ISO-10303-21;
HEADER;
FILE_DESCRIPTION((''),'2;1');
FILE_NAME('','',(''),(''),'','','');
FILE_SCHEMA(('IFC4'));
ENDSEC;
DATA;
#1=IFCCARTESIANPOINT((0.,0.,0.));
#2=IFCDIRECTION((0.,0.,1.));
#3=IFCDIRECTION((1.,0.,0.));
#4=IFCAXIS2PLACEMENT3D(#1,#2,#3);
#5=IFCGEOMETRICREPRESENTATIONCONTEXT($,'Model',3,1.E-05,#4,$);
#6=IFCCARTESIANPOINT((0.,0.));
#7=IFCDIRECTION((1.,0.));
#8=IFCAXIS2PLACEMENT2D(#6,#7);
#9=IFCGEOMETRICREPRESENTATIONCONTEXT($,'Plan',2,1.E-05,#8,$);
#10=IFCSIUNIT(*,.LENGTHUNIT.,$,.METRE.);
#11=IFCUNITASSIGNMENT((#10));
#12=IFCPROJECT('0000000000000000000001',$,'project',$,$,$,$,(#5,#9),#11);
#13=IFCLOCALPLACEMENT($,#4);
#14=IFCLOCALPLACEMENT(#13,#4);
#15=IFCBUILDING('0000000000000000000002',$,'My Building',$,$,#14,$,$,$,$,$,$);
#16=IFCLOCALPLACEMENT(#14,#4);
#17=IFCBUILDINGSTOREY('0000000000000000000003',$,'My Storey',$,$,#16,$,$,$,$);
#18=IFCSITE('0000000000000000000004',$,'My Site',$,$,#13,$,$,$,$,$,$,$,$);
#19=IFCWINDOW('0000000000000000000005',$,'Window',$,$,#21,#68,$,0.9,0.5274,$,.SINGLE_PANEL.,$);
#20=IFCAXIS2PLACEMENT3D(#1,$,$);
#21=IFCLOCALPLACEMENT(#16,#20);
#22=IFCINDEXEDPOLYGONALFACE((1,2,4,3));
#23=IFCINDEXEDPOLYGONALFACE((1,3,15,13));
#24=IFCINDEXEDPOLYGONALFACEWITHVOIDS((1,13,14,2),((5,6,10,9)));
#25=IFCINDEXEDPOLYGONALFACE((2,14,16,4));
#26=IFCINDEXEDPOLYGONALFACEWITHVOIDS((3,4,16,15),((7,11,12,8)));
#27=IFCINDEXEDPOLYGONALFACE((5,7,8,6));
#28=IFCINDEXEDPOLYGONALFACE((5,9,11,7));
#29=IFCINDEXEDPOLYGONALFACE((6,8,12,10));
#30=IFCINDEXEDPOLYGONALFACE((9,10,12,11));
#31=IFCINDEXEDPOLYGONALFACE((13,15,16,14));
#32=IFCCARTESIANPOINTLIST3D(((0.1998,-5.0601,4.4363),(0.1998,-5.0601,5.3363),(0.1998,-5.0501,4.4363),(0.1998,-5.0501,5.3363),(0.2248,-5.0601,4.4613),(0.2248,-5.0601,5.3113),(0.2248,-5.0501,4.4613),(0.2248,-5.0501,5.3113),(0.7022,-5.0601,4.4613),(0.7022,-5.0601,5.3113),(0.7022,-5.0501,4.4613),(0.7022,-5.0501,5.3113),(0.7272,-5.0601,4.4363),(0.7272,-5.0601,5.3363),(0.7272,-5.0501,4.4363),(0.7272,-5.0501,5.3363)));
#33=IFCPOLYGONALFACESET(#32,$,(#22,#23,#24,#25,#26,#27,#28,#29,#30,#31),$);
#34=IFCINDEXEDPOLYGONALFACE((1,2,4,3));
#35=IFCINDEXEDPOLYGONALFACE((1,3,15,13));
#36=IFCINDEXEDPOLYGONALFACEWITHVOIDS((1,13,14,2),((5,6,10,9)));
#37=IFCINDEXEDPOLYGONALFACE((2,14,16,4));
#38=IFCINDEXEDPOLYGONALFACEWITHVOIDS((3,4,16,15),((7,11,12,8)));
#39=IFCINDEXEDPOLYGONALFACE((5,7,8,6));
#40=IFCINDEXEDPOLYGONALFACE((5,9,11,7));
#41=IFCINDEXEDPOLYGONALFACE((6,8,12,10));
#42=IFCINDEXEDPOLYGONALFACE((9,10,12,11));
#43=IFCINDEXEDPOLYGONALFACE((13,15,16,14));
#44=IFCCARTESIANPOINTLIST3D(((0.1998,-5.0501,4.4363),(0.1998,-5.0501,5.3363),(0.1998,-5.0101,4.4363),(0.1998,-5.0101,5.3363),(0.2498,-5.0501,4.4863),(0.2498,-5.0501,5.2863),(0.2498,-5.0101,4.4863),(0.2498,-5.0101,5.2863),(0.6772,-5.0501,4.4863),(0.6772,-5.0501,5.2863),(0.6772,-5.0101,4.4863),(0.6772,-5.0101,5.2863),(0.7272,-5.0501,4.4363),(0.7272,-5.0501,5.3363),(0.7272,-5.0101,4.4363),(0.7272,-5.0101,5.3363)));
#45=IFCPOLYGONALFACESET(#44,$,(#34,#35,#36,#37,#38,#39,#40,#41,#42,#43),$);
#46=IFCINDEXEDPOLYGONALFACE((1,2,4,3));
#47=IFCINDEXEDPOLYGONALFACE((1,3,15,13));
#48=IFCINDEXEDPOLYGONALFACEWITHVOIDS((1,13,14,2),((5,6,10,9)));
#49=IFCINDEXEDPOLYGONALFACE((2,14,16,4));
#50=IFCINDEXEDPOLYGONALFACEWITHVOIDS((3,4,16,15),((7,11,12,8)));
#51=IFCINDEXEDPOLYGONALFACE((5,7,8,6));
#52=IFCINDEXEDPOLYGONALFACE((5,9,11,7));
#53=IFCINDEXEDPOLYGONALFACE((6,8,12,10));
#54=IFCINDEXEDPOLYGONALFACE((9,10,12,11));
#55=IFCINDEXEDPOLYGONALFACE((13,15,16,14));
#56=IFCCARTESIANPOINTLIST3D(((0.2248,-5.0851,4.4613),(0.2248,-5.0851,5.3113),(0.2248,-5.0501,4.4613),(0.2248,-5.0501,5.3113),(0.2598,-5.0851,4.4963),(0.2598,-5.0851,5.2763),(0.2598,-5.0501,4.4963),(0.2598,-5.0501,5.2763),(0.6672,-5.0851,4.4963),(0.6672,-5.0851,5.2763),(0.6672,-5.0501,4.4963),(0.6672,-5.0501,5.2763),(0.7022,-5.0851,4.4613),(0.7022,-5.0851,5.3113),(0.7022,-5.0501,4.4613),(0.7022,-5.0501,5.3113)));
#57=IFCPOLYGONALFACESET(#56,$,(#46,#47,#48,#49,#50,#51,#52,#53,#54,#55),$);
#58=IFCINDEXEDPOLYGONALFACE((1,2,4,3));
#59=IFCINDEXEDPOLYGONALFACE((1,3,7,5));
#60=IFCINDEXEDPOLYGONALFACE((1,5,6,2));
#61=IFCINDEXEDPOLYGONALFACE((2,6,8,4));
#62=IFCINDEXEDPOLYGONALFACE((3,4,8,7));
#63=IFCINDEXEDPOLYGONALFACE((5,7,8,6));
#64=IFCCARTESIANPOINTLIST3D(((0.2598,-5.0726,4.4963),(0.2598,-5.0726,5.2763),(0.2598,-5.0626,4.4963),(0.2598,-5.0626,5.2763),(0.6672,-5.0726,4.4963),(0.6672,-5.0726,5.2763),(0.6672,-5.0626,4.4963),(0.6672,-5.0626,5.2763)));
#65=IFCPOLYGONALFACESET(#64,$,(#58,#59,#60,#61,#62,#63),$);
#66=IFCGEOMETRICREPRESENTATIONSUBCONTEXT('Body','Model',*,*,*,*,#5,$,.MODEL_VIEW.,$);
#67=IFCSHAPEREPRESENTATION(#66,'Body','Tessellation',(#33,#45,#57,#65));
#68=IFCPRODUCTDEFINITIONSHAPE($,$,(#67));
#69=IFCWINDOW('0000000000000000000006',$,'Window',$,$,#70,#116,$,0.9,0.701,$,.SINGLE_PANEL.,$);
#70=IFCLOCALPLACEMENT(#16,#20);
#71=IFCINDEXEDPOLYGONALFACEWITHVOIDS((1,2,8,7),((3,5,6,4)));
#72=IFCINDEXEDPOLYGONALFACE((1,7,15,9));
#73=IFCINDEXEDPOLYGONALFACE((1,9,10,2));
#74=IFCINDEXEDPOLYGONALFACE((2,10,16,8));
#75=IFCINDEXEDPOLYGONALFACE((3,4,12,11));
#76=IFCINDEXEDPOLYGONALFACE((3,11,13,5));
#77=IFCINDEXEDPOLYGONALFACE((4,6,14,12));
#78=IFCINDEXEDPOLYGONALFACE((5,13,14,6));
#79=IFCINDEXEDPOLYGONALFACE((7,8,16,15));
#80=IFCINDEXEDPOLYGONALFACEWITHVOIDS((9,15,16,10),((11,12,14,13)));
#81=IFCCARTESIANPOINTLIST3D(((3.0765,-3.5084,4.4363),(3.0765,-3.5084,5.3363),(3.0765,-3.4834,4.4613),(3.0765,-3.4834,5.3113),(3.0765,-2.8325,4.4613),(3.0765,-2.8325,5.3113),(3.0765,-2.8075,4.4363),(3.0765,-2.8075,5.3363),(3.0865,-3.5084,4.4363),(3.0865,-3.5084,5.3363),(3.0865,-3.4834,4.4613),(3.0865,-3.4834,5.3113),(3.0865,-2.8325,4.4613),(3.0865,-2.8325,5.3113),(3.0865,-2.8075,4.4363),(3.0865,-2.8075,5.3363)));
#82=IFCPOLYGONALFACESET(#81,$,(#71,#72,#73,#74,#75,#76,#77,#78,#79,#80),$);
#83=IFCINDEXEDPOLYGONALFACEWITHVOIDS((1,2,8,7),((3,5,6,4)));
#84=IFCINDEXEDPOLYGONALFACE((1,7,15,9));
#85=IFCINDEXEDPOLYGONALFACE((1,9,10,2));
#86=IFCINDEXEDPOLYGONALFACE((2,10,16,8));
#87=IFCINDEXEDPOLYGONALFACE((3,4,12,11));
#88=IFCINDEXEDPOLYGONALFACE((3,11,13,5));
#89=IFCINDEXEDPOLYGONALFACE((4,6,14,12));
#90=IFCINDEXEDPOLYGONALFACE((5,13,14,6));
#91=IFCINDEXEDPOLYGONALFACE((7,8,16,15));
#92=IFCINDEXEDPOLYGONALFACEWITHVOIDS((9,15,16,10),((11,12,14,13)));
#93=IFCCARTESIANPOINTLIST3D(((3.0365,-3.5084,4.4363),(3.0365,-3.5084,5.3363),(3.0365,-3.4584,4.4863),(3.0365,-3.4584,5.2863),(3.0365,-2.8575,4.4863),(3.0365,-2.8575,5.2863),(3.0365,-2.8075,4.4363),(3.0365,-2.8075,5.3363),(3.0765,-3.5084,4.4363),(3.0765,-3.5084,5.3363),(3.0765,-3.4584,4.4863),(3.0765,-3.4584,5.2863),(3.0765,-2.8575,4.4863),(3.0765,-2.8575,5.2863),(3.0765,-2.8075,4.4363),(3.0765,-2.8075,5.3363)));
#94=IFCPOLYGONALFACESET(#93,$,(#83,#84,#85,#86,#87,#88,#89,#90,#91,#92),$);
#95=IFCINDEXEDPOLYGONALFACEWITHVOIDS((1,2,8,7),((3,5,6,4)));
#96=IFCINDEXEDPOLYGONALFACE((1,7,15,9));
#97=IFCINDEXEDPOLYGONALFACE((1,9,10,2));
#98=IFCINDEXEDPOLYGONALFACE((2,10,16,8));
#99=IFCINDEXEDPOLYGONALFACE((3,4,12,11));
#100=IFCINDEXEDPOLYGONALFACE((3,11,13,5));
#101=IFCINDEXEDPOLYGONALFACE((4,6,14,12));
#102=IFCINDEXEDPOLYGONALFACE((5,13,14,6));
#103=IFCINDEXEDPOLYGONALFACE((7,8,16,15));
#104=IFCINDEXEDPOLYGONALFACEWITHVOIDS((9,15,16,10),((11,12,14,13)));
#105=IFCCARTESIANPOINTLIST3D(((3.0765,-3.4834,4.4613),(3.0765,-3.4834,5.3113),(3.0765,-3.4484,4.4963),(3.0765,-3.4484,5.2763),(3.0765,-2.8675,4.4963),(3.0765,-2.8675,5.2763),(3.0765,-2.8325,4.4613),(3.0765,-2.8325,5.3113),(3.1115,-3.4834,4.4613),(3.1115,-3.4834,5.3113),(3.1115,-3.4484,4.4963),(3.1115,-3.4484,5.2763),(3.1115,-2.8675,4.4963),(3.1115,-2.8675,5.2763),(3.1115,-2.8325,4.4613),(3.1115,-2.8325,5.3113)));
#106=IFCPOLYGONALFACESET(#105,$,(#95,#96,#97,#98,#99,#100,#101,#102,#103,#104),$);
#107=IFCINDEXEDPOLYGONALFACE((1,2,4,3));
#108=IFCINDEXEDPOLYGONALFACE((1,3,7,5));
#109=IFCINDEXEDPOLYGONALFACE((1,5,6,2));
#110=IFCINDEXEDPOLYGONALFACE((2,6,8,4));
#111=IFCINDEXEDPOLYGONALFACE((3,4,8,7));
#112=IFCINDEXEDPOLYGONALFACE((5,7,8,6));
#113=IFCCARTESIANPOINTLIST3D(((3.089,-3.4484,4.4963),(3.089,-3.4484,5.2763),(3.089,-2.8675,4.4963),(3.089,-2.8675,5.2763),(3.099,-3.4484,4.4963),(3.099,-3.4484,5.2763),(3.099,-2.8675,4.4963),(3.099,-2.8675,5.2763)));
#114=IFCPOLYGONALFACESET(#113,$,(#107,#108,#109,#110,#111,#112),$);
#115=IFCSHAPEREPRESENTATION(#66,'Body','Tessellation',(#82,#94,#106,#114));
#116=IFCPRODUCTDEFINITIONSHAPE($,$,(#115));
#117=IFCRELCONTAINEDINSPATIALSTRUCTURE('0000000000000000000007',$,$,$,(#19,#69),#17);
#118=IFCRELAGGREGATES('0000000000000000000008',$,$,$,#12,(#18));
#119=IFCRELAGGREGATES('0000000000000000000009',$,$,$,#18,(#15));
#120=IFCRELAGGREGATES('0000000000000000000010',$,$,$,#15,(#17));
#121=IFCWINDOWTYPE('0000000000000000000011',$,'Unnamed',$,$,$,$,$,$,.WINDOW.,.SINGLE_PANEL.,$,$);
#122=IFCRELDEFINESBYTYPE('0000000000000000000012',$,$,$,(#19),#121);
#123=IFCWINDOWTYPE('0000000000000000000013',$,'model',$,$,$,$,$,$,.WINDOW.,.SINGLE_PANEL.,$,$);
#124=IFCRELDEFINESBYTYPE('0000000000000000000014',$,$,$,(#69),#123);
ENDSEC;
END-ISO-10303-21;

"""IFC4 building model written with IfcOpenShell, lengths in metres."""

from ifc_helpers import new_model, entity, si_unit, frame, origin_with_axes, origin_2d_with_axis, place, context, subcontext, project, spatial, line, indexed_curve, outline, extrude, shape, source, transform, mapped, type_object, type_shapes, element, save


model = new_model("IFC4")

# Units and contexts
model_context = context("Model", 3, precision=1e-05, world=origin_with_axes())
plan_context = context("Plan", 2, precision=1e-05, world=origin_2d_with_axis())
body_context_1 = subcontext(model_context, "Body", "Model", "MODEL_VIEW")
body_context_2 = subcontext(plan_context, "Body", "Plan", "PLAN_VIEW")
ifc_project = project(units=[si_unit("LENGTHUNIT", "METRE")], contexts=[model_context, plan_context])

# Site, building, storey
site_placement = place(None, origin_with_axes())
site = spatial("IfcSite", under=ifc_project, at=site_placement, Name="My Site")
building_placement = place(site_placement, origin_with_axes())
building = spatial("IfcBuilding", under=site, at=building_placement, Name="My Building")
storey_placement = place(building_placement, origin_with_axes())
storey = spatial("IfcBuildingStorey", under=building, at=storey_placement, Name="My Storey")

# Shared definitions
window_type_1 = type_object("IfcWindowType", Name="Unnamed", PartitioningType="SINGLE_PANEL", PredefinedType="WINDOW")
shared_shape_1 = source(origin_with_axes(), body_context_1, "Body", "SweptSolid", [
    extrude(outline(indexed_curve([(0.0, 0.0), (0.5274, 0.0), (0.5274, 0.9), (0.0, 0.9)], segments=[line(1, 2, 3, 4, 1)]), holes=[indexed_curve([(0.025, 0.025), (0.5024, 0.025), (0.5024, 0.875), (0.025, 0.875)], segments=[line(1, 2, 3, 4, 1)])]), frame((0.0, 0.09, 0.0), z_axis=(0.0, -1.0, 0.0), x_axis=(1.0, 0.0, 0.0)), (0.0, 0.0, -1.0), 0.01),
    extrude(outline(indexed_curve([(0.0, 0.0), (0.5274, 0.0), (0.5274, 0.9), (0.0, 0.9)], segments=[line(1, 2, 3, 4, 1)]), holes=[indexed_curve([(0.05, 0.05), (0.4774, 0.05), (0.4774, 0.85), (0.05, 0.85)], segments=[line(1, 2, 3, 4, 1)])]), frame((0.0, 0.05, 0.0), z_axis=(0.0, -1.0, 0.0), x_axis=(1.0, 0.0, 0.0)), (0.0, 0.0, -1.0), 0.04),
    extrude(outline(indexed_curve([(0.0, 0.0), (0.4774, 0.0), (0.4774, 0.85), (0.0, 0.85)], segments=[line(1, 2, 3, 4, 1)]), holes=[indexed_curve([(0.035, 0.035), (0.4424, 0.035), (0.4424, 0.815), (0.035, 0.815)], segments=[line(1, 2, 3, 4, 1)])]), frame((0.025, 0.09, 0.025), z_axis=(0.0, -1.0, 0.0), x_axis=(1.0, 0.0, 0.0)), (0.0, 0.0, -1.0), 0.035),
    extrude(outline(indexed_curve([(0.035, 0.035), (0.4424, 0.035), (0.4424, 0.815), (0.035, 0.815)], segments=[line(1, 2, 3, 4, 1)])), frame((0.025, 0.1025, 0.025), z_axis=(0.0, -1.0, 0.0), x_axis=(1.0, 0.0, 0.0)), (0.0, 0.0, -1.0), 0.01),
])
shared_shape_2 = source(origin_with_axes(), body_context_2, "Body", "Curve2D", [
    entity("IfcIndexedPolyCurve", entity("IfcCartesianPointList2D", [[0.05, 0.05], [0.4774, 0.05]])),
    entity("IfcIndexedPolyCurve", entity("IfcCartesianPointList2D", [[0.0, 0.1], [0.025, 0.1], [0.025, 0.09], [0.05, 0.09], [0.05, 0.05], [0.0, 0.05]]), [entity("IfcLineIndex", [1, 2, 3, 4, 5, 6, 1])]),
    entity("IfcIndexedPolyCurve", entity("IfcCartesianPointList2D", [[0.5274, 0.1], [0.5024, 0.1], [0.5024, 0.09], [0.4774, 0.09], [0.4774, 0.05], [0.5274, 0.05]]), [entity("IfcLineIndex", [1, 2, 3, 4, 5, 6, 1])]),
    entity("IfcIndexedPolyCurve", entity("IfcCartesianPointList2D", [[0.025, 0.09], [0.06, 0.09], [0.06, 0.125], [0.025, 0.125]]), [entity("IfcLineIndex", [1, 2, 3, 4, 1])]),
    entity("IfcIndexedPolyCurve", entity("IfcCartesianPointList2D", [[0.5024, 0.09], [0.4674, 0.09], [0.4674, 0.125], [0.5024, 0.125]]), [entity("IfcLineIndex", [1, 2, 3, 4, 1])]),
    entity("IfcIndexedPolyCurve", entity("IfcCartesianPointList2D", [[0.06, 0.09], [0.4674, 0.09]])),
    entity("IfcIndexedPolyCurve", entity("IfcCartesianPointList2D", [[0.06, 0.125], [0.4674, 0.125]])),
    entity("IfcIndexedPolyCurve", entity("IfcCartesianPointList2D", [[0.06, 0.1075], [0.4674, 0.1075]])),
])
type_shapes(window_type_1, [shared_shape_1, shared_shape_2])

# Windows
for number, where, z_axis, x_axis, name in (
    (1, (0.7272, -4.9601, 4.4363), (0.0, 0.0, 1.0), (-1.0, 0.0, 0.0), "Window"),
):
    element("IfcWindow", number, at=place(storey_placement, frame(where, z_axis=z_axis, x_axis=x_axis)), inside=storey, type_object=window_type_1, Name=name, OverallHeight=0.9, OverallWidth=0.5274, PartitioningType="SINGLE_PANEL", shapes=[
        shape(body_context_1, "Body", "MappedRepresentation", [mapped(shared_shape_1, transform((0.0, 0.0, 0.0), x_axis=(1.0, 0.0, 0.0), y_axis=(0.0, 1.0, 0.0), z_axis=(0.0, 0.0, 1.0), scale=1.0))]),
        shape(body_context_2, "Body", "MappedRepresentation", [mapped(shared_shape_2, transform((0.0, 0.0, 0.0), x_axis=(1.0, 0.0, 0.0), y_axis=(0.0, 1.0, 0.0), z_axis=(0.0, 0.0, 1.0), scale=1.0))]),
    ])
window_type_2 = type_object("IfcWindowType", Name="model", PartitioningType="SINGLE_PANEL", PredefinedType="WINDOW")
shared_shape_3 = source(origin_with_axes(), body_context_1, "Body", "SweptSolid", [
    extrude(outline(indexed_curve([(0.0, 0.0), (0.701, 0.0), (0.701, 0.9), (0.0, 0.9)], segments=[line(1, 2, 3, 4, 1)]), holes=[indexed_curve([(0.025, 0.025), (0.676, 0.025), (0.676, 0.875), (0.025, 0.875)], segments=[line(1, 2, 3, 4, 1)])]), frame((0.0, 0.09, 0.0), z_axis=(0.0, -1.0, 0.0), x_axis=(1.0, 0.0, 0.0)), (0.0, 0.0, -1.0), 0.01),
    extrude(outline(indexed_curve([(0.0, 0.0), (0.701, 0.0), (0.701, 0.9), (0.0, 0.9)], segments=[line(1, 2, 3, 4, 1)]), holes=[indexed_curve([(0.05, 0.05), (0.651, 0.05), (0.651, 0.85), (0.05, 0.85)], segments=[line(1, 2, 3, 4, 1)])]), frame((0.0, 0.05, 0.0), z_axis=(0.0, -1.0, 0.0), x_axis=(1.0, 0.0, 0.0)), (0.0, 0.0, -1.0), 0.04),
    extrude(outline(indexed_curve([(0.0, 0.0), (0.651, 0.0), (0.651, 0.85), (0.0, 0.85)], segments=[line(1, 2, 3, 4, 1)]), holes=[indexed_curve([(0.035, 0.035), (0.616, 0.035), (0.616, 0.815), (0.035, 0.815)], segments=[line(1, 2, 3, 4, 1)])]), frame((0.025, 0.09, 0.025), z_axis=(0.0, -1.0, 0.0), x_axis=(1.0, 0.0, 0.0)), (0.0, 0.0, -1.0), 0.035),
    extrude(outline(indexed_curve([(0.035, 0.035), (0.616, 0.035), (0.616, 0.815), (0.035, 0.815)], segments=[line(1, 2, 3, 4, 1)])), frame((0.025, 0.1025, 0.025), z_axis=(0.0, -1.0, 0.0), x_axis=(1.0, 0.0, 0.0)), (0.0, 0.0, -1.0), 0.01),
])
shared_shape_4 = source(origin_with_axes(), body_context_2, "Body", "Curve2D", [
    entity("IfcIndexedPolyCurve", entity("IfcCartesianPointList2D", [[0.05, 0.05], [0.651, 0.05]])),
    entity("IfcIndexedPolyCurve", entity("IfcCartesianPointList2D", [[0.0, 0.1], [0.025, 0.1], [0.025, 0.09], [0.05, 0.09], [0.05, 0.05], [0.0, 0.05]]), [entity("IfcLineIndex", [1, 2, 3, 4, 5, 6, 1])]),
    entity("IfcIndexedPolyCurve", entity("IfcCartesianPointList2D", [[0.701, 0.1], [0.676, 0.1], [0.676, 0.09], [0.651, 0.09], [0.651, 0.05], [0.701, 0.05]]), [entity("IfcLineIndex", [1, 2, 3, 4, 5, 6, 1])]),
    entity("IfcIndexedPolyCurve", entity("IfcCartesianPointList2D", [[0.025, 0.09], [0.06, 0.09], [0.06, 0.125], [0.025, 0.125]]), [entity("IfcLineIndex", [1, 2, 3, 4, 1])]),
    entity("IfcIndexedPolyCurve", entity("IfcCartesianPointList2D", [[0.676, 0.09], [0.641, 0.09], [0.641, 0.125], [0.676, 0.125]]), [entity("IfcLineIndex", [1, 2, 3, 4, 1])]),
    entity("IfcIndexedPolyCurve", entity("IfcCartesianPointList2D", [[0.06, 0.09], [0.641, 0.09]])),
    entity("IfcIndexedPolyCurve", entity("IfcCartesianPointList2D", [[0.06, 0.125], [0.641, 0.125]])),
    entity("IfcIndexedPolyCurve", entity("IfcCartesianPointList2D", [[0.06, 0.1075], [0.641, 0.1075]])),
])
type_shapes(window_type_2, [shared_shape_3, shared_shape_4])
window_1_placement = place(storey_placement, frame((2.9865, -2.8075, 4.4363), z_axis=(0.0, 0.0, 1.0), x_axis=(0.0, -1.0, 0.0)))
element("IfcWindow", 2, at=window_1_placement, inside=storey, type_object=window_type_2, Name="Window", OverallHeight=0.9, OverallWidth=0.701, PartitioningType="SINGLE_PANEL", shapes=[
    shape(body_context_1, "Body", "MappedRepresentation", [mapped(shared_shape_3, transform((0.0, 0.0, 0.0), x_axis=(1.0, 0.0, 0.0), y_axis=(0.0, 1.0, 0.0), z_axis=(0.0, 0.0, 1.0), scale=1.0))]),
    shape(body_context_2, "Body", "MappedRepresentation", [mapped(shared_shape_4, transform((0.0, 0.0, 0.0), x_axis=(1.0, 0.0, 0.0), y_axis=(0.0, 1.0, 0.0), z_axis=(0.0, 0.0, 1.0), scale=1.0))]),
])

save(model, "model.ifc")
